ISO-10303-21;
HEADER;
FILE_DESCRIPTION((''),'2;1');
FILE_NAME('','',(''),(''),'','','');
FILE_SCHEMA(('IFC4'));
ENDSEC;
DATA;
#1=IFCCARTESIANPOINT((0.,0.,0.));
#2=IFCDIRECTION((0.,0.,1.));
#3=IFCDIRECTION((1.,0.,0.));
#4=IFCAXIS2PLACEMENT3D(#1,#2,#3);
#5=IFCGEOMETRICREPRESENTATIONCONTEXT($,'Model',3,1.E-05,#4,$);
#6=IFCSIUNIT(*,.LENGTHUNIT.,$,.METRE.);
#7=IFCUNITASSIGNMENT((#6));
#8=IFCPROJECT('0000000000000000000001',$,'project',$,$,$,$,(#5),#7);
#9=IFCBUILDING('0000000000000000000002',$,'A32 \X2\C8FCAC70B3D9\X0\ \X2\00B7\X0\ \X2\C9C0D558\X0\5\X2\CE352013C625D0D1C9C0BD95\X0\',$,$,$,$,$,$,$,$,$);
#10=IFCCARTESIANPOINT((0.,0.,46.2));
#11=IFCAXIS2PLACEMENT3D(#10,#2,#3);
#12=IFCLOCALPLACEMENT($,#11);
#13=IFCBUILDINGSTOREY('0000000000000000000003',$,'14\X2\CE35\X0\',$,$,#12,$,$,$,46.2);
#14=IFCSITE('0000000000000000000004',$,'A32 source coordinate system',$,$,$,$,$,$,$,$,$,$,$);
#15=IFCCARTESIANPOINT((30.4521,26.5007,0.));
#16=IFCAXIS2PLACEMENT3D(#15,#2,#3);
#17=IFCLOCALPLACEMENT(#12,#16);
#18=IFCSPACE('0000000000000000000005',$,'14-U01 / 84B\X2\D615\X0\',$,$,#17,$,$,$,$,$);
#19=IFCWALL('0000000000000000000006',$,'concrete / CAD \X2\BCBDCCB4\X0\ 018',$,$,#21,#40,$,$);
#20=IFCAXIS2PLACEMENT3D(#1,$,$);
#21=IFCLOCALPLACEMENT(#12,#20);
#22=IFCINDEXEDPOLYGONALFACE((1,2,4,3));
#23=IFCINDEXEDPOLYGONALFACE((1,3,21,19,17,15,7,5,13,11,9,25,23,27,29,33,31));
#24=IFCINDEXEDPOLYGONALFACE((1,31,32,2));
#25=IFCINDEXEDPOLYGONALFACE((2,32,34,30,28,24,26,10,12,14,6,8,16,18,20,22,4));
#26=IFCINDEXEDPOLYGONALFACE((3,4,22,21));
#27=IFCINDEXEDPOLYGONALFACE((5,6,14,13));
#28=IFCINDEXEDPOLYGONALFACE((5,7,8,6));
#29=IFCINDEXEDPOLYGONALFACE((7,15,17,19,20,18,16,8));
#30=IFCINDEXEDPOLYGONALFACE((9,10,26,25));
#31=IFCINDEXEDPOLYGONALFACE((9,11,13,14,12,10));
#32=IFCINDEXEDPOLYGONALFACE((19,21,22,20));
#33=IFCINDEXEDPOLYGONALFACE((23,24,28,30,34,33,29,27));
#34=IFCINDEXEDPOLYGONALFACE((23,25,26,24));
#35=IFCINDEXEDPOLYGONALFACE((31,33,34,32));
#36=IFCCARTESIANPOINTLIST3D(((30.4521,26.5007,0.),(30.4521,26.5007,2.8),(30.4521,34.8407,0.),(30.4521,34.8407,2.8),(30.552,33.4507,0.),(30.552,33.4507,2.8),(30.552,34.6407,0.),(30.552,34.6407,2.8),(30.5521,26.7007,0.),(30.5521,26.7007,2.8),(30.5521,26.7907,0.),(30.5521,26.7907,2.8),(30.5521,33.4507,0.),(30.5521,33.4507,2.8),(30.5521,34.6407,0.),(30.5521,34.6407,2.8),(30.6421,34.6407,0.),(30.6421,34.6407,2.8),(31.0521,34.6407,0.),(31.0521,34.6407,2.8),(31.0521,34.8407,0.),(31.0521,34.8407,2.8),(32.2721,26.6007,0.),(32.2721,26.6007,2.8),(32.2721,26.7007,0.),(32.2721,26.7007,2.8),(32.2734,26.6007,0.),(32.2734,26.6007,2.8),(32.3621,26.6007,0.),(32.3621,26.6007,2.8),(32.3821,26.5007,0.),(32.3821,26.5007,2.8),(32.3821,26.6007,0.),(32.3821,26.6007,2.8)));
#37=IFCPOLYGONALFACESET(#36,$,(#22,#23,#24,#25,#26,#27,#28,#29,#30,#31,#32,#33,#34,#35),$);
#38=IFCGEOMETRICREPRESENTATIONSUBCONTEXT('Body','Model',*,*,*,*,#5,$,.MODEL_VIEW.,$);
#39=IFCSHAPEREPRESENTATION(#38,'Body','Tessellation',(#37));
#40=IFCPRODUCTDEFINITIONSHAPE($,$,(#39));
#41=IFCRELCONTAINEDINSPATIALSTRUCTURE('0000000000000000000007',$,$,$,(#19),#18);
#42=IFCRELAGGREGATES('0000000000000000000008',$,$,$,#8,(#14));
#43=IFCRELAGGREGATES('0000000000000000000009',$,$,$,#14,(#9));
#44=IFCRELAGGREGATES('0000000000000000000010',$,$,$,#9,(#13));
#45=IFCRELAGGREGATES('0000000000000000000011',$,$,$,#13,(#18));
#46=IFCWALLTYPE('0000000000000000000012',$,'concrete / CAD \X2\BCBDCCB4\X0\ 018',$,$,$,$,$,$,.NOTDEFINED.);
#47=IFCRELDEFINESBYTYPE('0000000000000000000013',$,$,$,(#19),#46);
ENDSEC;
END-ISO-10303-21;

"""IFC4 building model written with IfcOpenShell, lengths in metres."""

from ifc_helpers import new_model, si_unit, frame, origin, origin_with_axes, place, context, subcontext, project, spatial, polyline, outline, extrude, source, transform, mapped, type_object, type_shapes, element, save


model = new_model("IFC4")

# Units and contexts
model_context = context("Model", 3, precision=1e-05, world=origin_with_axes())
body_context = subcontext(model_context, "Body", "Model", "MODEL_VIEW")
ifc_project = project(units=[si_unit("LENGTHUNIT", "METRE")], contexts=[model_context])

# Site, building, storey, space
site = spatial("IfcSite", under=ifc_project, Name="A32 source coordinate system")
building = spatial("IfcBuilding", under=site, Name="A32 주거동 · 지하5층–옥탑지붕")
storey_placement = place(None, frame((0.0, 0.0, 46.2), z_axis=(0.0, 0.0, 1.0), x_axis=(1.0, 0.0, 0.0)))
storey = spatial("IfcBuildingStorey", under=building, at=storey_placement, Name="14층", Elevation=46.2)
space_1_placement = place(storey_placement, frame((30.4521, 26.5007, 0.0), z_axis=(0.0, 0.0, 1.0), x_axis=(1.0, 0.0, 0.0)))
space_1 = spatial("IfcSpace", under=storey, at=space_1_placement, Name="14-U01 / 84B형")

# Wall
wall_type_1 = type_object("IfcWallType", Name="concrete / CAD 벽체 018", PredefinedType="NOTDEFINED")
shared_shape_1 = source(origin(), body_context, "Body", "SweptSolid", [
    extrude(outline(polyline([(0.6, 8.34), (0.6, 8.14), (0.19, 8.14), (0.1, 8.14), (0.0999, 8.14), (0.0999, 6.95), (0.1, 6.95), (0.1, 0.29), (0.1, 0.2), (1.82, 0.2), (1.82, 0.1), (1.8213, 0.1), (1.91, 0.1), (1.93, 0.1), (1.93, 0.0), (0.0, 0.0), (0.0, 8.34), (-0.35, 8.34), (-0.35, 8.34), (0.6, 8.34)])), origin(), (0.0, 0.0, 1.0), 2.8),
])
type_shapes(wall_type_1, [shared_shape_1])
wall_1_placement = place(space_1_placement, origin_with_axes())
element("IfcWall", 1, at=wall_1_placement, inside=space_1, type_object=wall_type_1, Name="concrete / CAD 벽체 018", context=body_context, shape_type="MappedRepresentation", body=[
    mapped(shared_shape_1, transform((0.0, 0.0, 0.0), scale=1.0)),
])

save(model, "model.ifc")
